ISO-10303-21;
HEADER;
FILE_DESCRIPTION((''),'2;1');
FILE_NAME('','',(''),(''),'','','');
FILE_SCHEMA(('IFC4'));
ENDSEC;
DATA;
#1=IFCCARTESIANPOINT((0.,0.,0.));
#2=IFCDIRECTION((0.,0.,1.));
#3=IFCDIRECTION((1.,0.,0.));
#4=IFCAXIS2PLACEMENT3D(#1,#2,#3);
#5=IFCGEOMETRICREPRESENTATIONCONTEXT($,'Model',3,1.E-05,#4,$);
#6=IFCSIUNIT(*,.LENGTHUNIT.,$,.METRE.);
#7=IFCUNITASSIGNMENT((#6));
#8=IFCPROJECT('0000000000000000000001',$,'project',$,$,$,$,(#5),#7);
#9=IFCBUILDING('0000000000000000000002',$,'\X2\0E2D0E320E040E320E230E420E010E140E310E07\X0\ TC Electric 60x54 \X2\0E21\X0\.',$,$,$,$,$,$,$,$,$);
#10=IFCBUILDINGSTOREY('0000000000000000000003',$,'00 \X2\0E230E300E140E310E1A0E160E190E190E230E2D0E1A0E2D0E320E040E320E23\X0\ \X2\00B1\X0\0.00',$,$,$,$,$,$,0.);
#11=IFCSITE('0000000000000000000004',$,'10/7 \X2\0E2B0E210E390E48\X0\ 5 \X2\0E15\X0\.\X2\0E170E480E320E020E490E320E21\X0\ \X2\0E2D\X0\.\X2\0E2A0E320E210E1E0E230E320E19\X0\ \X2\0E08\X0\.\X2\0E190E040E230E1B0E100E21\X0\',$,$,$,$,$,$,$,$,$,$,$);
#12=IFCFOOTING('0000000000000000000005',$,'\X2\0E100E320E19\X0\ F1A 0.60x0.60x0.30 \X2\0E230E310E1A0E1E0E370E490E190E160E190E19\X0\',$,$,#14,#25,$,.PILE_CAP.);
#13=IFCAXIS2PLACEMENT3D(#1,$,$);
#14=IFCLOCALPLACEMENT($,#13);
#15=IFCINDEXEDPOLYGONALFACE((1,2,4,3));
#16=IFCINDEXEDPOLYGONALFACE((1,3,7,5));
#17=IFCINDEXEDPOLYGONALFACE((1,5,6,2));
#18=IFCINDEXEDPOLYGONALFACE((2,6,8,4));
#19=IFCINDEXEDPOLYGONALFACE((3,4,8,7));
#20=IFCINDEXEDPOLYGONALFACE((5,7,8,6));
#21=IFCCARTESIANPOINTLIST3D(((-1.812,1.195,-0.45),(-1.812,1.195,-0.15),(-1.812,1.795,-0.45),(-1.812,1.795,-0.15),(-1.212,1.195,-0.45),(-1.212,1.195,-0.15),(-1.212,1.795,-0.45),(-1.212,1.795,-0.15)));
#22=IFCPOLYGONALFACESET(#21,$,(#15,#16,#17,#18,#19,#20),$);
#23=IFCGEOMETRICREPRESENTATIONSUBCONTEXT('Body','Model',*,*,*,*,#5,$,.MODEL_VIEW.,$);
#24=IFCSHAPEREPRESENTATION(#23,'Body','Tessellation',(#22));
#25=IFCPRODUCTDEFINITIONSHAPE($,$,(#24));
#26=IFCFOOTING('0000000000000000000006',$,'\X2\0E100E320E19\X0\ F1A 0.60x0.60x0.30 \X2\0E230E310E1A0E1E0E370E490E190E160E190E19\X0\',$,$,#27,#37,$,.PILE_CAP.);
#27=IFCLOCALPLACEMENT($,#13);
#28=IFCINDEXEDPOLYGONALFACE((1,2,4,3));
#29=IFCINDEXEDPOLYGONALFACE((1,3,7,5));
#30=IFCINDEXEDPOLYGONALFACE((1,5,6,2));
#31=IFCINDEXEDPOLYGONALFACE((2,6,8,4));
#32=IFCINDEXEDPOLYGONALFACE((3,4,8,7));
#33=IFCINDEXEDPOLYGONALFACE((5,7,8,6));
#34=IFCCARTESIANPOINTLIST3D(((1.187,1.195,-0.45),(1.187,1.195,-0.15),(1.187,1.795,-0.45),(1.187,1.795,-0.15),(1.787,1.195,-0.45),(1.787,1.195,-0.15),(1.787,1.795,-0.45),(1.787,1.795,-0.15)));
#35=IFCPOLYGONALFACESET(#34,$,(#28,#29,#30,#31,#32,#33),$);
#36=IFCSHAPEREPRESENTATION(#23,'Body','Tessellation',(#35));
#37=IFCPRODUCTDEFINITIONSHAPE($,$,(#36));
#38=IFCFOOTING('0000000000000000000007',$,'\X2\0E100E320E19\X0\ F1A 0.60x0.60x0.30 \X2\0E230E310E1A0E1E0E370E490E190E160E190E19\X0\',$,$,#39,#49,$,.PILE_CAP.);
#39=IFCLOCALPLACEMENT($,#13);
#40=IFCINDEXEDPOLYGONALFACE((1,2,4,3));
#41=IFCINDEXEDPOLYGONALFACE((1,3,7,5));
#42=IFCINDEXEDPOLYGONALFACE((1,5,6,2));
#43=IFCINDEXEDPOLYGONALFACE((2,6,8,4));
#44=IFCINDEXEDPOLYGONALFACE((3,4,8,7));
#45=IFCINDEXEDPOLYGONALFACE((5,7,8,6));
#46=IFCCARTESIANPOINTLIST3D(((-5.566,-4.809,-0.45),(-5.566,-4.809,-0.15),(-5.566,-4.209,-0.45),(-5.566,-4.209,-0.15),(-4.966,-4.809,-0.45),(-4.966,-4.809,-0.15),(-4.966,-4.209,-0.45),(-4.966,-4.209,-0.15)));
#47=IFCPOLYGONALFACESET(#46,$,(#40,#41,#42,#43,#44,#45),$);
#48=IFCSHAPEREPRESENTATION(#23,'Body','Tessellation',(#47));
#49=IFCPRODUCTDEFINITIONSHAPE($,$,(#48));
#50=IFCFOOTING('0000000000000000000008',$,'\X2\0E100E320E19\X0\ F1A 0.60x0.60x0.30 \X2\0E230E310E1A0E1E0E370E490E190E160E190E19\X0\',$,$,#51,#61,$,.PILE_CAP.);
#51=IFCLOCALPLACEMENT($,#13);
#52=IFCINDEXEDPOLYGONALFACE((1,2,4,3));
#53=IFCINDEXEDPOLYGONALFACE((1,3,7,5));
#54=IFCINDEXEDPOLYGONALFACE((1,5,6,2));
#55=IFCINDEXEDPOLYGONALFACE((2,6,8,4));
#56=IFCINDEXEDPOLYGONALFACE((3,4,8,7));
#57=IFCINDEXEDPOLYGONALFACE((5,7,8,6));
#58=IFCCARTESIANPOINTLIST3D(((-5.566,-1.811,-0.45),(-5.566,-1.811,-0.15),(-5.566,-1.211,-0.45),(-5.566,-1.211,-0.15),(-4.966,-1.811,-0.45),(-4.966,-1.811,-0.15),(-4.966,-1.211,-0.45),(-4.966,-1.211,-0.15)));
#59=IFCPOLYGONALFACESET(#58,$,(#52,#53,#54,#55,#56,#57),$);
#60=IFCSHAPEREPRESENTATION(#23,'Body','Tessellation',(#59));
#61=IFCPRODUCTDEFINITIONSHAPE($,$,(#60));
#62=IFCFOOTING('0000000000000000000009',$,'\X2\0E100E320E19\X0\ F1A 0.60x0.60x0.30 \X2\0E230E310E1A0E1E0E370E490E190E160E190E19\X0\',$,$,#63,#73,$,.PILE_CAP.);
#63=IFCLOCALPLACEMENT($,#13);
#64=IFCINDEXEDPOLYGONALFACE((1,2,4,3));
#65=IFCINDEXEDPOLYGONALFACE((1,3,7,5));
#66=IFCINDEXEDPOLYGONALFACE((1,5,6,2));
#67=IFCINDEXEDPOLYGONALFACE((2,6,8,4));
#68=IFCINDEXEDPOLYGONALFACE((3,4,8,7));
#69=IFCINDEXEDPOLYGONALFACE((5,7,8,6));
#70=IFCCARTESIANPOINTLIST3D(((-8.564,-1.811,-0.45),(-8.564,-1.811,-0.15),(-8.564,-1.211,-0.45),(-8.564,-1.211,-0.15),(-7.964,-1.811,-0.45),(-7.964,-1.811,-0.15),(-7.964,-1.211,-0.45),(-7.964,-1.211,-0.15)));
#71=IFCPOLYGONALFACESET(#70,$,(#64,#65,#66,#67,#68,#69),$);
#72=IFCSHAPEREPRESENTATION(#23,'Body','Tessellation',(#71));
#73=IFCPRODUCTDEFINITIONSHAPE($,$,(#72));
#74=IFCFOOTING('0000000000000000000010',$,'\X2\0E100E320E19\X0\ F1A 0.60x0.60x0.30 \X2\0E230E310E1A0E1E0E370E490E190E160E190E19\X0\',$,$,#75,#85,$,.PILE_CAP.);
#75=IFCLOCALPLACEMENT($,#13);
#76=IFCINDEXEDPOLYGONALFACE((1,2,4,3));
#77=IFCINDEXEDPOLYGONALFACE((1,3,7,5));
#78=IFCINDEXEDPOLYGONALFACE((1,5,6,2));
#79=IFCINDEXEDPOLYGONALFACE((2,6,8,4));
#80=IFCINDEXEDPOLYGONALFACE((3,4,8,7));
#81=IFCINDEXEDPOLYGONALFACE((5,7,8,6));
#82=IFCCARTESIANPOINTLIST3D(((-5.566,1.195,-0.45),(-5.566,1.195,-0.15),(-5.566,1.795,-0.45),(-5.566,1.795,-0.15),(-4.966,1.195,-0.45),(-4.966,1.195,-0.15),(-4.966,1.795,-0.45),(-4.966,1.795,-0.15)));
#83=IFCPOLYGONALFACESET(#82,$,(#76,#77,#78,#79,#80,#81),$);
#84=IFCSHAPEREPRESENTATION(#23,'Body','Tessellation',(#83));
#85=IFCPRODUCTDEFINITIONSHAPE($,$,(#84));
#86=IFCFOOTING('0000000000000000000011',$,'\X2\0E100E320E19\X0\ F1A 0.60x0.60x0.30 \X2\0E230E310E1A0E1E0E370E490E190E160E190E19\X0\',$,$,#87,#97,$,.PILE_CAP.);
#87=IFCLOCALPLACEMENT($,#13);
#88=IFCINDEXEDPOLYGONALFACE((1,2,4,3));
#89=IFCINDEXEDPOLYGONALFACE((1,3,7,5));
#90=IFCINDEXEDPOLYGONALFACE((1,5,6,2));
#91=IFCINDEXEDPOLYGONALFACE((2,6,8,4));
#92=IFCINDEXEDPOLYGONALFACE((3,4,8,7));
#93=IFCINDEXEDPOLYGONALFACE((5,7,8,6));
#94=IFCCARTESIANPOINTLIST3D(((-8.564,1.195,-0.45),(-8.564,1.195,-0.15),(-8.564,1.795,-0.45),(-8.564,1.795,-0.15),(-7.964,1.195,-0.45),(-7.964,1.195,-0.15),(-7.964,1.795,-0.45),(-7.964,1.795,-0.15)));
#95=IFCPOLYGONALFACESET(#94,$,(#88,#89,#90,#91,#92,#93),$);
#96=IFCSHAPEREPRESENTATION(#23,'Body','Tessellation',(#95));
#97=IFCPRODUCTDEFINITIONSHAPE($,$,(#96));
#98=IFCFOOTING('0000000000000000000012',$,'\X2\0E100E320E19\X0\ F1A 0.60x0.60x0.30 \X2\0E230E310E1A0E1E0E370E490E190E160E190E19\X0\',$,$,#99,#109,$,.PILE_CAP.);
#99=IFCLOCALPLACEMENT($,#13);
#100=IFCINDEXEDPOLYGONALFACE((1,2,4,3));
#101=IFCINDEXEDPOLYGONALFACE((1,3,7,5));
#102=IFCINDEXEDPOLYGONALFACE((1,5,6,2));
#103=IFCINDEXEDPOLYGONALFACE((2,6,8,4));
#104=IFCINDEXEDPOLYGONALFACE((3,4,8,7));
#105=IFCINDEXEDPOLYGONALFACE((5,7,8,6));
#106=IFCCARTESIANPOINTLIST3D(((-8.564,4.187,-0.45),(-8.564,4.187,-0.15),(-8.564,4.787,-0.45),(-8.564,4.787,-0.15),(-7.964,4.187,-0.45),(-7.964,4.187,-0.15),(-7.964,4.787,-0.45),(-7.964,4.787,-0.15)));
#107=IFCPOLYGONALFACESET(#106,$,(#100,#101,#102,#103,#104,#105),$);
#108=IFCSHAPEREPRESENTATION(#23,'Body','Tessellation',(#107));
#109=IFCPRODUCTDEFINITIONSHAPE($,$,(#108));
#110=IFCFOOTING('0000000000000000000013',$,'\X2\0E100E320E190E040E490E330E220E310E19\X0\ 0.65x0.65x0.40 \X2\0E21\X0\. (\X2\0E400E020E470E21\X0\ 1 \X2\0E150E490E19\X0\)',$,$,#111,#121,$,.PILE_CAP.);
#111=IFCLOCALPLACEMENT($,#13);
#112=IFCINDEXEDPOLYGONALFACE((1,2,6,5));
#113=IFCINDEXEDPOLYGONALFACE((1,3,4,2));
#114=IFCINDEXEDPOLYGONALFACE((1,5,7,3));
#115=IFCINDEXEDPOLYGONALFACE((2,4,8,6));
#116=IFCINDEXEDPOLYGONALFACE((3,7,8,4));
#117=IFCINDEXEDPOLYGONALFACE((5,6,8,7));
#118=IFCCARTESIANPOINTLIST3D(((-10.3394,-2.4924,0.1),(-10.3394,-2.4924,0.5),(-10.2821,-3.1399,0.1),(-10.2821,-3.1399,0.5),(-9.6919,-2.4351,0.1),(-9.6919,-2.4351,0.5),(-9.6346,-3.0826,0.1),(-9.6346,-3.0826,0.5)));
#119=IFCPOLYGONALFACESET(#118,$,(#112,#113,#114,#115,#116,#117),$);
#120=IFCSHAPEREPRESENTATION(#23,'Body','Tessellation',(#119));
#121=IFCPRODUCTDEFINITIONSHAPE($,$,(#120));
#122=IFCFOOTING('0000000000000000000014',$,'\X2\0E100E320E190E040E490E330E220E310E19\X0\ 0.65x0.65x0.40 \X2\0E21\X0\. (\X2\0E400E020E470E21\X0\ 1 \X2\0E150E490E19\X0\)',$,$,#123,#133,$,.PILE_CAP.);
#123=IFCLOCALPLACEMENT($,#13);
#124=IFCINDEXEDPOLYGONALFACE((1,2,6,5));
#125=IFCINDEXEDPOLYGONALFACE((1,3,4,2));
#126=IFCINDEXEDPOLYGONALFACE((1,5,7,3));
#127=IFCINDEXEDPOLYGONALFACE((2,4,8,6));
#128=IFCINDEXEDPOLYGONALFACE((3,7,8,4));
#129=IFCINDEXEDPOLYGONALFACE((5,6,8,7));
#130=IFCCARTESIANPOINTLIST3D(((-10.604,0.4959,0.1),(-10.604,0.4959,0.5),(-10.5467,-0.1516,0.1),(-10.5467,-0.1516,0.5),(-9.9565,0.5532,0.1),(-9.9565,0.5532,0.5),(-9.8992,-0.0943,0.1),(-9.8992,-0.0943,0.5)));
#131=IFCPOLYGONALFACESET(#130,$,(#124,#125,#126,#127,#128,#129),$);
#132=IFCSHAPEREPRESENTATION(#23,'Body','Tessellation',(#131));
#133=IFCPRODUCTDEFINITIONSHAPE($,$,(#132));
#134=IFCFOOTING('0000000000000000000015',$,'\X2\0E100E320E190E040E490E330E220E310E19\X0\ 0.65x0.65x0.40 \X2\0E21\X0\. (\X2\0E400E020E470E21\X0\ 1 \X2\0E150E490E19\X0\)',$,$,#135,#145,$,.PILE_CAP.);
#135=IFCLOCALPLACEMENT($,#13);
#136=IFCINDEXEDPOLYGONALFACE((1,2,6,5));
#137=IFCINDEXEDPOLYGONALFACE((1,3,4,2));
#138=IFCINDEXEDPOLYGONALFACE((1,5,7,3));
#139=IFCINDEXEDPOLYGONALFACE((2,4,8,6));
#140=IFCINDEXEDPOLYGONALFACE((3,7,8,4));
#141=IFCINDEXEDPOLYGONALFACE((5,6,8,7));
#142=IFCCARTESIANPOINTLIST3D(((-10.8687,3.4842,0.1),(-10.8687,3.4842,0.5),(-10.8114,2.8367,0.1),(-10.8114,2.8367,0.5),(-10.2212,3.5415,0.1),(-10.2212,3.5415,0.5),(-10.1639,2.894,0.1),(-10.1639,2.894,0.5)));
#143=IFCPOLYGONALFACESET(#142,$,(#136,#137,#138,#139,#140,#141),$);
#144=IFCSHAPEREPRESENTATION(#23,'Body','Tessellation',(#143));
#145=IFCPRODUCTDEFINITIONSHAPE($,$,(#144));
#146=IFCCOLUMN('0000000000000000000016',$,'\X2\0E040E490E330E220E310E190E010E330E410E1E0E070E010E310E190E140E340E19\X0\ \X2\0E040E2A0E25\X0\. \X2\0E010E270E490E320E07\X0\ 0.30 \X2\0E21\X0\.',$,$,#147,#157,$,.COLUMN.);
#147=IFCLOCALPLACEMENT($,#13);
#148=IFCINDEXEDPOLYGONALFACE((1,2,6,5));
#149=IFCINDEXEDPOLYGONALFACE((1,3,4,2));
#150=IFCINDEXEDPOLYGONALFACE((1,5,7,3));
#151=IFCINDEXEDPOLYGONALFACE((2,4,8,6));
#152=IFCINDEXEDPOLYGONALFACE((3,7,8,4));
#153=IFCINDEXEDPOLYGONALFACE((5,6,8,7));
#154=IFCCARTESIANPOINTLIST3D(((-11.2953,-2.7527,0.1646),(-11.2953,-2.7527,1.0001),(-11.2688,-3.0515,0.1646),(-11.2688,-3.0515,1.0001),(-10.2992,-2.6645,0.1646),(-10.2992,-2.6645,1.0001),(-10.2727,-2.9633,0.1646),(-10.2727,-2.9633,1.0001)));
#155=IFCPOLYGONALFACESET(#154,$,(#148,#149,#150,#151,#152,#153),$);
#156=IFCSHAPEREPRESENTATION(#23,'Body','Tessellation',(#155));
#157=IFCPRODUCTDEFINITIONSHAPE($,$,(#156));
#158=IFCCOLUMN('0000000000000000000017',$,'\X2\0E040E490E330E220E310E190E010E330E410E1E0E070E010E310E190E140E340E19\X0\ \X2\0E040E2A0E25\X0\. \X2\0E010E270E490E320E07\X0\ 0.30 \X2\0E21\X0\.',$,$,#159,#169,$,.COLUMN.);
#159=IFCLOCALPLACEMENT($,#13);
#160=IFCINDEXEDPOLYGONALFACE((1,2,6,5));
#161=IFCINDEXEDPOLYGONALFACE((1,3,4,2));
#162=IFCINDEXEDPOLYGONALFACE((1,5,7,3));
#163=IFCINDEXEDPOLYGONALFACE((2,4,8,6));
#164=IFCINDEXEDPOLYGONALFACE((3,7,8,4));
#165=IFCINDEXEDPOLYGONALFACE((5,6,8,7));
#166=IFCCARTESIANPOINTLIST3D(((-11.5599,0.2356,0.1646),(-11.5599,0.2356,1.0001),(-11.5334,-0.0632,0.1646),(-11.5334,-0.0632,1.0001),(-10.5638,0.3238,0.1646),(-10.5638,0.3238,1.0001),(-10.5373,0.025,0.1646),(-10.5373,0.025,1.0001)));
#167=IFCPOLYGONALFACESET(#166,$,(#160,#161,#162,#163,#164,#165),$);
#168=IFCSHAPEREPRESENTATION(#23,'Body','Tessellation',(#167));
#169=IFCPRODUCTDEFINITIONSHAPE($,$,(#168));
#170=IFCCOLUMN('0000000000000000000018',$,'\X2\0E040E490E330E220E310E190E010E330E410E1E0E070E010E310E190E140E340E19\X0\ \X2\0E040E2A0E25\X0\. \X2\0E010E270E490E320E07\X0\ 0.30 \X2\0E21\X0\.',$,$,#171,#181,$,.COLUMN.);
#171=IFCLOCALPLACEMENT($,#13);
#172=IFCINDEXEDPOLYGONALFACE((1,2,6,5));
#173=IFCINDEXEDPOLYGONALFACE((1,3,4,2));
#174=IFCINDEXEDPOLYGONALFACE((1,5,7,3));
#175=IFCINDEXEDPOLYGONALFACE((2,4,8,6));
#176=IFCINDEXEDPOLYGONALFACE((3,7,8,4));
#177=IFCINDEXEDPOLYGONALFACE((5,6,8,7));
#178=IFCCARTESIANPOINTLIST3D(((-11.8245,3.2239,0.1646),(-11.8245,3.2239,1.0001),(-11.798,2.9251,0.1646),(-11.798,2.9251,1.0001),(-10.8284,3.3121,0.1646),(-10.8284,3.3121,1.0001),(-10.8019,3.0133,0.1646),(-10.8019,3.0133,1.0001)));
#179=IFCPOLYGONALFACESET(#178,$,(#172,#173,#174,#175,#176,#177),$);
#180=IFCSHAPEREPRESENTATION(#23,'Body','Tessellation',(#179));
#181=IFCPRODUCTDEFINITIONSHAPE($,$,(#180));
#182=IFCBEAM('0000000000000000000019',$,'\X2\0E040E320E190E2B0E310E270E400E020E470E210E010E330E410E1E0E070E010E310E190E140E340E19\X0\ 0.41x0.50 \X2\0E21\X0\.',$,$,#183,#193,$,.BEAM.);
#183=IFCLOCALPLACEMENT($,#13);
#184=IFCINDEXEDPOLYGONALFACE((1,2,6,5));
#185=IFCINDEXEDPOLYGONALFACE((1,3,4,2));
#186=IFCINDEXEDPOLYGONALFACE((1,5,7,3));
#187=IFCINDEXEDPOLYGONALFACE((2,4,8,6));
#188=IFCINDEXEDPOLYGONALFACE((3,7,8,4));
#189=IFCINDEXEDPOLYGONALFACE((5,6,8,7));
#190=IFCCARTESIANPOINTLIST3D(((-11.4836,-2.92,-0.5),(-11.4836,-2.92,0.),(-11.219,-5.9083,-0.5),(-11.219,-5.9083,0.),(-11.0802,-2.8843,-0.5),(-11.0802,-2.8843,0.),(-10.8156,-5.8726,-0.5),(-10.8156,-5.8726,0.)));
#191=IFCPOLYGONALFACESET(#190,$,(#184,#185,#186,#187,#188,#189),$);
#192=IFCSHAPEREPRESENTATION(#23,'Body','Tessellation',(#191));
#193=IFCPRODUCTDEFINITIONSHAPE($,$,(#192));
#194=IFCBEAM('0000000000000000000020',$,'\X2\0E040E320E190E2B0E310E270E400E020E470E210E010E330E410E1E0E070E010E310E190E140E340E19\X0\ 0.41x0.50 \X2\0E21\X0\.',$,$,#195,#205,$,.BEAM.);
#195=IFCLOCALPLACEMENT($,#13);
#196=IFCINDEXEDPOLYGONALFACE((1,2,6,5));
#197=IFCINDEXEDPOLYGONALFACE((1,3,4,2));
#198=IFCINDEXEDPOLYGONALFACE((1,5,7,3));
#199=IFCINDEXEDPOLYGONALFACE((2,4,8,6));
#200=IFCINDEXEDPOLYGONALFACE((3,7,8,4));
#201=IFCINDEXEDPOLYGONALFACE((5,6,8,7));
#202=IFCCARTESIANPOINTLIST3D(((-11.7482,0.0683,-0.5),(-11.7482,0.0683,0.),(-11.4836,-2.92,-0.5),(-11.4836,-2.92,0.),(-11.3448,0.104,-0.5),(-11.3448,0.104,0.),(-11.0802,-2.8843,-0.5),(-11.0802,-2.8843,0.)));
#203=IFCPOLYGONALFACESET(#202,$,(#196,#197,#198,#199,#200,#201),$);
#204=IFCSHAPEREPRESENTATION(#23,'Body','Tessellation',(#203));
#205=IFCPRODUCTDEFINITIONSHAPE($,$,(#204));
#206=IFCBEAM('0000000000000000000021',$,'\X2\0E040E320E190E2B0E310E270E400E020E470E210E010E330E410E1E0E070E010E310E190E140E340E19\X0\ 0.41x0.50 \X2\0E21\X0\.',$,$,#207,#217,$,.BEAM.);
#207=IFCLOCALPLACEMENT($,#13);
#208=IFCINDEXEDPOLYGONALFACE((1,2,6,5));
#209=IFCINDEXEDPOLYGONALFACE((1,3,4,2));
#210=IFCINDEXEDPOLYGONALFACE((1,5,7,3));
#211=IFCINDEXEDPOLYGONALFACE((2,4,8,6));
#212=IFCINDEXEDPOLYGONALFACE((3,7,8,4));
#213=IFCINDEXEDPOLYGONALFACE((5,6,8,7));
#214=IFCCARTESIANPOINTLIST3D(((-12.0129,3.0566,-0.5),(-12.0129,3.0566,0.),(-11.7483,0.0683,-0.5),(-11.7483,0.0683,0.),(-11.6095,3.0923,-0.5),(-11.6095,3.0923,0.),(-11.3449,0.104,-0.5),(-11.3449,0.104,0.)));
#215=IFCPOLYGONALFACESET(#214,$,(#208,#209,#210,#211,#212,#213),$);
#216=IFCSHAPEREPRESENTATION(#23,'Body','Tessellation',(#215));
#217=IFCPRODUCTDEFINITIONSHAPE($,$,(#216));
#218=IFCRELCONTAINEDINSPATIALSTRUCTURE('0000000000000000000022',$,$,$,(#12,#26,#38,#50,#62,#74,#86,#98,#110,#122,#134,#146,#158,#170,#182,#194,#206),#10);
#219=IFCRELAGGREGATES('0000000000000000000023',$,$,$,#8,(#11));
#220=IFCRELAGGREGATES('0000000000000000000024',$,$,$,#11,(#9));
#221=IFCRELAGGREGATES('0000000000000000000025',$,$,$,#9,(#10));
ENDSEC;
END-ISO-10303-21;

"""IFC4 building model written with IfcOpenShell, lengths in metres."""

from ifc_helpers import new_model, si_unit, frame, origin, origin_with_axes, origin_2d, place, context, subcontext, project, spatial, rectangle, extrude, element, save


model = new_model("IFC4")

# Units and contexts
model_context = context("Model", 3, precision=1e-05, world=origin_with_axes())
body_context = subcontext(model_context, "Body", "Model", "MODEL_VIEW")
ifc_project = project(units=[si_unit("LENGTHUNIT", "METRE")], contexts=[model_context])

# Site, building, storey
site = spatial("IfcSite", under=ifc_project, Name="10/7 หมู่ 5 ต.ท่าข้าม อ.สามพราน จ.นครปฐม")
building = spatial("IfcBuilding", under=site, Name="อาคารโกดัง TC Electric 60x54 ม.")
storey = spatial("IfcBuildingStorey", under=building, Name="00 ระดับถนนรอบอาคาร ±0.00", Elevation=0.0)

# Footings
for number, where, z_axis, x_axis, name in (
    (1, (-1.512, 1.495, -0.45), (0.0, 0.0, 1.0), (1.0, 0.0, 0.0), "ฐาน F1A 0.60x0.60x0.30 รับพื้นถนน"),
    (2, (1.487, 1.495, -0.45), (0.0, 0.0, 1.0), (1.0, 0.0, 0.0), "ฐาน F1A 0.60x0.60x0.30 รับพื้นถนน"),
    (3, (-5.266, -4.509, -0.45), (0.0, 0.0, 1.0), (1.0, 0.0, 0.0), "ฐาน F1A 0.60x0.60x0.30 รับพื้นถนน"),
    (4, (-5.266, -1.511, -0.45), (0.0, 0.0, 1.0), (1.0, 0.0, 0.0), "ฐาน F1A 0.60x0.60x0.30 รับพื้นถนน"),
    (5, (-8.264, -1.511, -0.45), (0.0, 0.0, 1.0), (1.0, 0.0, 0.0), "ฐาน F1A 0.60x0.60x0.30 รับพื้นถนน"),
    (6, (-5.266, 1.495, -0.45), (0.0, 0.0, 1.0), (1.0, 0.0, 0.0), "ฐาน F1A 0.60x0.60x0.30 รับพื้นถนน"),
    (7, (-8.264, 1.495, -0.45), (0.0, 0.0, 1.0), (1.0, 0.0, 0.0), "ฐาน F1A 0.60x0.60x0.30 รับพื้นถนน"),
    (8, (-8.264, 4.487, -0.45), (0.0, 0.0, 1.0), (1.0, 0.0, 0.0), "ฐาน F1A 0.60x0.60x0.30 รับพื้นถนน"),
):
    element("IfcFooting", number, at=place(None, frame(where, z_axis=z_axis, x_axis=x_axis)), inside=storey, Name=name, PredefinedType="PILE_CAP", context=body_context, shape_type="SweptSolid", body=[
        extrude(rectangle(XDim=0.6, YDim=0.6, at=origin_2d()), origin(), (0.0, 0.0, 1.0), 0.3),
    ])
for number, where, z_axis, x_axis, name in (
    (9, (-9.987, -2.7875, 0.1), (0.0, 0.0, 1.0), (0.9961, 0.0882, 0.0), "ฐานค้ำยัน 0.65x0.65x0.40 ม. (เข็ม 1 ต้น)"),
    (10, (-10.2516, 0.2008, 0.1), (0.0, 0.0, 1.0), (0.9961, 0.0882, 0.0), "ฐานค้ำยัน 0.65x0.65x0.40 ม. (เข็ม 1 ต้น)"),
    (11, (-10.5163, 3.1891, 0.1), (0.0, 0.0, 1.0), (0.9961, 0.0882, 0.0), "ฐานค้ำยัน 0.65x0.65x0.40 ม. (เข็ม 1 ต้น)"),
):
    element("IfcFooting", number, at=place(None, frame(where, z_axis=z_axis, x_axis=x_axis)), inside=storey, Name=name, PredefinedType="PILE_CAP", context=body_context, shape_type="SweptSolid", body=[
        extrude(rectangle(XDim=0.65, YDim=0.65, at=origin_2d()), origin(), (0.0, 0.0, 1.0), 0.4),
    ])

# Columns
for number, where, z_axis, x_axis, name in (
    (12, (-10.784, -2.858, 0.1646), (0.0, 0.0, 1.0), (0.9961, 0.0882, 0.0), "ค้ำยันกำแพงกันดิน คสล. กว้าง 0.30 ม."),
    (13, (-11.0486, 0.1303, 0.1646), (0.0, 0.0, 1.0), (0.9961, 0.0882, 0.0), "ค้ำยันกำแพงกันดิน คสล. กว้าง 0.30 ม."),
    (14, (-11.3132, 3.1186, 0.1646), (0.0, 0.0, 1.0), (0.9961, 0.0882, 0.0), "ค้ำยันกำแพงกันดิน คสล. กว้าง 0.30 ม."),
):
    element("IfcColumn", number, at=place(None, frame(where, z_axis=z_axis, x_axis=x_axis)), inside=storey, Name=name, PredefinedType="COLUMN", context=body_context, shape_type="SweptSolid", body=[
        extrude(rectangle(XDim=1.0, YDim=0.3, at=origin_2d()), origin(), (0.0, 0.0, 1.0), 0.8355),
    ])

# Beams
for number, where, z_axis, x_axis, name in (
    (15, (-11.1496, -4.3963, -0.5), (0.0, 0.0, 1.0), (-0.0882, 0.9961, 0.0), "คานหัวเข็มกำแพงกันดิน 0.41x0.50 ม."),
    (16, (-11.4142, -1.408, -0.5), (0.0, 0.0, 1.0), (-0.0882, 0.9961, 0.0), "คานหัวเข็มกำแพงกันดิน 0.41x0.50 ม."),
    (17, (-11.6789, 1.5803, -0.5), (0.0, 0.0, 1.0), (-0.0882, 0.9961, 0.0), "คานหัวเข็มกำแพงกันดิน 0.41x0.50 ม."),
):
    element("IfcBeam", number, at=place(None, frame(where, z_axis=z_axis, x_axis=x_axis)), inside=storey, Name=name, PredefinedType="BEAM", context=body_context, shape_type="SweptSolid", body=[
        extrude(rectangle(XDim=3.0, YDim=0.405, at=origin_2d()), origin(), (0.0, 0.0, 1.0), 0.5),
    ])

save(model, "model.ifc")
